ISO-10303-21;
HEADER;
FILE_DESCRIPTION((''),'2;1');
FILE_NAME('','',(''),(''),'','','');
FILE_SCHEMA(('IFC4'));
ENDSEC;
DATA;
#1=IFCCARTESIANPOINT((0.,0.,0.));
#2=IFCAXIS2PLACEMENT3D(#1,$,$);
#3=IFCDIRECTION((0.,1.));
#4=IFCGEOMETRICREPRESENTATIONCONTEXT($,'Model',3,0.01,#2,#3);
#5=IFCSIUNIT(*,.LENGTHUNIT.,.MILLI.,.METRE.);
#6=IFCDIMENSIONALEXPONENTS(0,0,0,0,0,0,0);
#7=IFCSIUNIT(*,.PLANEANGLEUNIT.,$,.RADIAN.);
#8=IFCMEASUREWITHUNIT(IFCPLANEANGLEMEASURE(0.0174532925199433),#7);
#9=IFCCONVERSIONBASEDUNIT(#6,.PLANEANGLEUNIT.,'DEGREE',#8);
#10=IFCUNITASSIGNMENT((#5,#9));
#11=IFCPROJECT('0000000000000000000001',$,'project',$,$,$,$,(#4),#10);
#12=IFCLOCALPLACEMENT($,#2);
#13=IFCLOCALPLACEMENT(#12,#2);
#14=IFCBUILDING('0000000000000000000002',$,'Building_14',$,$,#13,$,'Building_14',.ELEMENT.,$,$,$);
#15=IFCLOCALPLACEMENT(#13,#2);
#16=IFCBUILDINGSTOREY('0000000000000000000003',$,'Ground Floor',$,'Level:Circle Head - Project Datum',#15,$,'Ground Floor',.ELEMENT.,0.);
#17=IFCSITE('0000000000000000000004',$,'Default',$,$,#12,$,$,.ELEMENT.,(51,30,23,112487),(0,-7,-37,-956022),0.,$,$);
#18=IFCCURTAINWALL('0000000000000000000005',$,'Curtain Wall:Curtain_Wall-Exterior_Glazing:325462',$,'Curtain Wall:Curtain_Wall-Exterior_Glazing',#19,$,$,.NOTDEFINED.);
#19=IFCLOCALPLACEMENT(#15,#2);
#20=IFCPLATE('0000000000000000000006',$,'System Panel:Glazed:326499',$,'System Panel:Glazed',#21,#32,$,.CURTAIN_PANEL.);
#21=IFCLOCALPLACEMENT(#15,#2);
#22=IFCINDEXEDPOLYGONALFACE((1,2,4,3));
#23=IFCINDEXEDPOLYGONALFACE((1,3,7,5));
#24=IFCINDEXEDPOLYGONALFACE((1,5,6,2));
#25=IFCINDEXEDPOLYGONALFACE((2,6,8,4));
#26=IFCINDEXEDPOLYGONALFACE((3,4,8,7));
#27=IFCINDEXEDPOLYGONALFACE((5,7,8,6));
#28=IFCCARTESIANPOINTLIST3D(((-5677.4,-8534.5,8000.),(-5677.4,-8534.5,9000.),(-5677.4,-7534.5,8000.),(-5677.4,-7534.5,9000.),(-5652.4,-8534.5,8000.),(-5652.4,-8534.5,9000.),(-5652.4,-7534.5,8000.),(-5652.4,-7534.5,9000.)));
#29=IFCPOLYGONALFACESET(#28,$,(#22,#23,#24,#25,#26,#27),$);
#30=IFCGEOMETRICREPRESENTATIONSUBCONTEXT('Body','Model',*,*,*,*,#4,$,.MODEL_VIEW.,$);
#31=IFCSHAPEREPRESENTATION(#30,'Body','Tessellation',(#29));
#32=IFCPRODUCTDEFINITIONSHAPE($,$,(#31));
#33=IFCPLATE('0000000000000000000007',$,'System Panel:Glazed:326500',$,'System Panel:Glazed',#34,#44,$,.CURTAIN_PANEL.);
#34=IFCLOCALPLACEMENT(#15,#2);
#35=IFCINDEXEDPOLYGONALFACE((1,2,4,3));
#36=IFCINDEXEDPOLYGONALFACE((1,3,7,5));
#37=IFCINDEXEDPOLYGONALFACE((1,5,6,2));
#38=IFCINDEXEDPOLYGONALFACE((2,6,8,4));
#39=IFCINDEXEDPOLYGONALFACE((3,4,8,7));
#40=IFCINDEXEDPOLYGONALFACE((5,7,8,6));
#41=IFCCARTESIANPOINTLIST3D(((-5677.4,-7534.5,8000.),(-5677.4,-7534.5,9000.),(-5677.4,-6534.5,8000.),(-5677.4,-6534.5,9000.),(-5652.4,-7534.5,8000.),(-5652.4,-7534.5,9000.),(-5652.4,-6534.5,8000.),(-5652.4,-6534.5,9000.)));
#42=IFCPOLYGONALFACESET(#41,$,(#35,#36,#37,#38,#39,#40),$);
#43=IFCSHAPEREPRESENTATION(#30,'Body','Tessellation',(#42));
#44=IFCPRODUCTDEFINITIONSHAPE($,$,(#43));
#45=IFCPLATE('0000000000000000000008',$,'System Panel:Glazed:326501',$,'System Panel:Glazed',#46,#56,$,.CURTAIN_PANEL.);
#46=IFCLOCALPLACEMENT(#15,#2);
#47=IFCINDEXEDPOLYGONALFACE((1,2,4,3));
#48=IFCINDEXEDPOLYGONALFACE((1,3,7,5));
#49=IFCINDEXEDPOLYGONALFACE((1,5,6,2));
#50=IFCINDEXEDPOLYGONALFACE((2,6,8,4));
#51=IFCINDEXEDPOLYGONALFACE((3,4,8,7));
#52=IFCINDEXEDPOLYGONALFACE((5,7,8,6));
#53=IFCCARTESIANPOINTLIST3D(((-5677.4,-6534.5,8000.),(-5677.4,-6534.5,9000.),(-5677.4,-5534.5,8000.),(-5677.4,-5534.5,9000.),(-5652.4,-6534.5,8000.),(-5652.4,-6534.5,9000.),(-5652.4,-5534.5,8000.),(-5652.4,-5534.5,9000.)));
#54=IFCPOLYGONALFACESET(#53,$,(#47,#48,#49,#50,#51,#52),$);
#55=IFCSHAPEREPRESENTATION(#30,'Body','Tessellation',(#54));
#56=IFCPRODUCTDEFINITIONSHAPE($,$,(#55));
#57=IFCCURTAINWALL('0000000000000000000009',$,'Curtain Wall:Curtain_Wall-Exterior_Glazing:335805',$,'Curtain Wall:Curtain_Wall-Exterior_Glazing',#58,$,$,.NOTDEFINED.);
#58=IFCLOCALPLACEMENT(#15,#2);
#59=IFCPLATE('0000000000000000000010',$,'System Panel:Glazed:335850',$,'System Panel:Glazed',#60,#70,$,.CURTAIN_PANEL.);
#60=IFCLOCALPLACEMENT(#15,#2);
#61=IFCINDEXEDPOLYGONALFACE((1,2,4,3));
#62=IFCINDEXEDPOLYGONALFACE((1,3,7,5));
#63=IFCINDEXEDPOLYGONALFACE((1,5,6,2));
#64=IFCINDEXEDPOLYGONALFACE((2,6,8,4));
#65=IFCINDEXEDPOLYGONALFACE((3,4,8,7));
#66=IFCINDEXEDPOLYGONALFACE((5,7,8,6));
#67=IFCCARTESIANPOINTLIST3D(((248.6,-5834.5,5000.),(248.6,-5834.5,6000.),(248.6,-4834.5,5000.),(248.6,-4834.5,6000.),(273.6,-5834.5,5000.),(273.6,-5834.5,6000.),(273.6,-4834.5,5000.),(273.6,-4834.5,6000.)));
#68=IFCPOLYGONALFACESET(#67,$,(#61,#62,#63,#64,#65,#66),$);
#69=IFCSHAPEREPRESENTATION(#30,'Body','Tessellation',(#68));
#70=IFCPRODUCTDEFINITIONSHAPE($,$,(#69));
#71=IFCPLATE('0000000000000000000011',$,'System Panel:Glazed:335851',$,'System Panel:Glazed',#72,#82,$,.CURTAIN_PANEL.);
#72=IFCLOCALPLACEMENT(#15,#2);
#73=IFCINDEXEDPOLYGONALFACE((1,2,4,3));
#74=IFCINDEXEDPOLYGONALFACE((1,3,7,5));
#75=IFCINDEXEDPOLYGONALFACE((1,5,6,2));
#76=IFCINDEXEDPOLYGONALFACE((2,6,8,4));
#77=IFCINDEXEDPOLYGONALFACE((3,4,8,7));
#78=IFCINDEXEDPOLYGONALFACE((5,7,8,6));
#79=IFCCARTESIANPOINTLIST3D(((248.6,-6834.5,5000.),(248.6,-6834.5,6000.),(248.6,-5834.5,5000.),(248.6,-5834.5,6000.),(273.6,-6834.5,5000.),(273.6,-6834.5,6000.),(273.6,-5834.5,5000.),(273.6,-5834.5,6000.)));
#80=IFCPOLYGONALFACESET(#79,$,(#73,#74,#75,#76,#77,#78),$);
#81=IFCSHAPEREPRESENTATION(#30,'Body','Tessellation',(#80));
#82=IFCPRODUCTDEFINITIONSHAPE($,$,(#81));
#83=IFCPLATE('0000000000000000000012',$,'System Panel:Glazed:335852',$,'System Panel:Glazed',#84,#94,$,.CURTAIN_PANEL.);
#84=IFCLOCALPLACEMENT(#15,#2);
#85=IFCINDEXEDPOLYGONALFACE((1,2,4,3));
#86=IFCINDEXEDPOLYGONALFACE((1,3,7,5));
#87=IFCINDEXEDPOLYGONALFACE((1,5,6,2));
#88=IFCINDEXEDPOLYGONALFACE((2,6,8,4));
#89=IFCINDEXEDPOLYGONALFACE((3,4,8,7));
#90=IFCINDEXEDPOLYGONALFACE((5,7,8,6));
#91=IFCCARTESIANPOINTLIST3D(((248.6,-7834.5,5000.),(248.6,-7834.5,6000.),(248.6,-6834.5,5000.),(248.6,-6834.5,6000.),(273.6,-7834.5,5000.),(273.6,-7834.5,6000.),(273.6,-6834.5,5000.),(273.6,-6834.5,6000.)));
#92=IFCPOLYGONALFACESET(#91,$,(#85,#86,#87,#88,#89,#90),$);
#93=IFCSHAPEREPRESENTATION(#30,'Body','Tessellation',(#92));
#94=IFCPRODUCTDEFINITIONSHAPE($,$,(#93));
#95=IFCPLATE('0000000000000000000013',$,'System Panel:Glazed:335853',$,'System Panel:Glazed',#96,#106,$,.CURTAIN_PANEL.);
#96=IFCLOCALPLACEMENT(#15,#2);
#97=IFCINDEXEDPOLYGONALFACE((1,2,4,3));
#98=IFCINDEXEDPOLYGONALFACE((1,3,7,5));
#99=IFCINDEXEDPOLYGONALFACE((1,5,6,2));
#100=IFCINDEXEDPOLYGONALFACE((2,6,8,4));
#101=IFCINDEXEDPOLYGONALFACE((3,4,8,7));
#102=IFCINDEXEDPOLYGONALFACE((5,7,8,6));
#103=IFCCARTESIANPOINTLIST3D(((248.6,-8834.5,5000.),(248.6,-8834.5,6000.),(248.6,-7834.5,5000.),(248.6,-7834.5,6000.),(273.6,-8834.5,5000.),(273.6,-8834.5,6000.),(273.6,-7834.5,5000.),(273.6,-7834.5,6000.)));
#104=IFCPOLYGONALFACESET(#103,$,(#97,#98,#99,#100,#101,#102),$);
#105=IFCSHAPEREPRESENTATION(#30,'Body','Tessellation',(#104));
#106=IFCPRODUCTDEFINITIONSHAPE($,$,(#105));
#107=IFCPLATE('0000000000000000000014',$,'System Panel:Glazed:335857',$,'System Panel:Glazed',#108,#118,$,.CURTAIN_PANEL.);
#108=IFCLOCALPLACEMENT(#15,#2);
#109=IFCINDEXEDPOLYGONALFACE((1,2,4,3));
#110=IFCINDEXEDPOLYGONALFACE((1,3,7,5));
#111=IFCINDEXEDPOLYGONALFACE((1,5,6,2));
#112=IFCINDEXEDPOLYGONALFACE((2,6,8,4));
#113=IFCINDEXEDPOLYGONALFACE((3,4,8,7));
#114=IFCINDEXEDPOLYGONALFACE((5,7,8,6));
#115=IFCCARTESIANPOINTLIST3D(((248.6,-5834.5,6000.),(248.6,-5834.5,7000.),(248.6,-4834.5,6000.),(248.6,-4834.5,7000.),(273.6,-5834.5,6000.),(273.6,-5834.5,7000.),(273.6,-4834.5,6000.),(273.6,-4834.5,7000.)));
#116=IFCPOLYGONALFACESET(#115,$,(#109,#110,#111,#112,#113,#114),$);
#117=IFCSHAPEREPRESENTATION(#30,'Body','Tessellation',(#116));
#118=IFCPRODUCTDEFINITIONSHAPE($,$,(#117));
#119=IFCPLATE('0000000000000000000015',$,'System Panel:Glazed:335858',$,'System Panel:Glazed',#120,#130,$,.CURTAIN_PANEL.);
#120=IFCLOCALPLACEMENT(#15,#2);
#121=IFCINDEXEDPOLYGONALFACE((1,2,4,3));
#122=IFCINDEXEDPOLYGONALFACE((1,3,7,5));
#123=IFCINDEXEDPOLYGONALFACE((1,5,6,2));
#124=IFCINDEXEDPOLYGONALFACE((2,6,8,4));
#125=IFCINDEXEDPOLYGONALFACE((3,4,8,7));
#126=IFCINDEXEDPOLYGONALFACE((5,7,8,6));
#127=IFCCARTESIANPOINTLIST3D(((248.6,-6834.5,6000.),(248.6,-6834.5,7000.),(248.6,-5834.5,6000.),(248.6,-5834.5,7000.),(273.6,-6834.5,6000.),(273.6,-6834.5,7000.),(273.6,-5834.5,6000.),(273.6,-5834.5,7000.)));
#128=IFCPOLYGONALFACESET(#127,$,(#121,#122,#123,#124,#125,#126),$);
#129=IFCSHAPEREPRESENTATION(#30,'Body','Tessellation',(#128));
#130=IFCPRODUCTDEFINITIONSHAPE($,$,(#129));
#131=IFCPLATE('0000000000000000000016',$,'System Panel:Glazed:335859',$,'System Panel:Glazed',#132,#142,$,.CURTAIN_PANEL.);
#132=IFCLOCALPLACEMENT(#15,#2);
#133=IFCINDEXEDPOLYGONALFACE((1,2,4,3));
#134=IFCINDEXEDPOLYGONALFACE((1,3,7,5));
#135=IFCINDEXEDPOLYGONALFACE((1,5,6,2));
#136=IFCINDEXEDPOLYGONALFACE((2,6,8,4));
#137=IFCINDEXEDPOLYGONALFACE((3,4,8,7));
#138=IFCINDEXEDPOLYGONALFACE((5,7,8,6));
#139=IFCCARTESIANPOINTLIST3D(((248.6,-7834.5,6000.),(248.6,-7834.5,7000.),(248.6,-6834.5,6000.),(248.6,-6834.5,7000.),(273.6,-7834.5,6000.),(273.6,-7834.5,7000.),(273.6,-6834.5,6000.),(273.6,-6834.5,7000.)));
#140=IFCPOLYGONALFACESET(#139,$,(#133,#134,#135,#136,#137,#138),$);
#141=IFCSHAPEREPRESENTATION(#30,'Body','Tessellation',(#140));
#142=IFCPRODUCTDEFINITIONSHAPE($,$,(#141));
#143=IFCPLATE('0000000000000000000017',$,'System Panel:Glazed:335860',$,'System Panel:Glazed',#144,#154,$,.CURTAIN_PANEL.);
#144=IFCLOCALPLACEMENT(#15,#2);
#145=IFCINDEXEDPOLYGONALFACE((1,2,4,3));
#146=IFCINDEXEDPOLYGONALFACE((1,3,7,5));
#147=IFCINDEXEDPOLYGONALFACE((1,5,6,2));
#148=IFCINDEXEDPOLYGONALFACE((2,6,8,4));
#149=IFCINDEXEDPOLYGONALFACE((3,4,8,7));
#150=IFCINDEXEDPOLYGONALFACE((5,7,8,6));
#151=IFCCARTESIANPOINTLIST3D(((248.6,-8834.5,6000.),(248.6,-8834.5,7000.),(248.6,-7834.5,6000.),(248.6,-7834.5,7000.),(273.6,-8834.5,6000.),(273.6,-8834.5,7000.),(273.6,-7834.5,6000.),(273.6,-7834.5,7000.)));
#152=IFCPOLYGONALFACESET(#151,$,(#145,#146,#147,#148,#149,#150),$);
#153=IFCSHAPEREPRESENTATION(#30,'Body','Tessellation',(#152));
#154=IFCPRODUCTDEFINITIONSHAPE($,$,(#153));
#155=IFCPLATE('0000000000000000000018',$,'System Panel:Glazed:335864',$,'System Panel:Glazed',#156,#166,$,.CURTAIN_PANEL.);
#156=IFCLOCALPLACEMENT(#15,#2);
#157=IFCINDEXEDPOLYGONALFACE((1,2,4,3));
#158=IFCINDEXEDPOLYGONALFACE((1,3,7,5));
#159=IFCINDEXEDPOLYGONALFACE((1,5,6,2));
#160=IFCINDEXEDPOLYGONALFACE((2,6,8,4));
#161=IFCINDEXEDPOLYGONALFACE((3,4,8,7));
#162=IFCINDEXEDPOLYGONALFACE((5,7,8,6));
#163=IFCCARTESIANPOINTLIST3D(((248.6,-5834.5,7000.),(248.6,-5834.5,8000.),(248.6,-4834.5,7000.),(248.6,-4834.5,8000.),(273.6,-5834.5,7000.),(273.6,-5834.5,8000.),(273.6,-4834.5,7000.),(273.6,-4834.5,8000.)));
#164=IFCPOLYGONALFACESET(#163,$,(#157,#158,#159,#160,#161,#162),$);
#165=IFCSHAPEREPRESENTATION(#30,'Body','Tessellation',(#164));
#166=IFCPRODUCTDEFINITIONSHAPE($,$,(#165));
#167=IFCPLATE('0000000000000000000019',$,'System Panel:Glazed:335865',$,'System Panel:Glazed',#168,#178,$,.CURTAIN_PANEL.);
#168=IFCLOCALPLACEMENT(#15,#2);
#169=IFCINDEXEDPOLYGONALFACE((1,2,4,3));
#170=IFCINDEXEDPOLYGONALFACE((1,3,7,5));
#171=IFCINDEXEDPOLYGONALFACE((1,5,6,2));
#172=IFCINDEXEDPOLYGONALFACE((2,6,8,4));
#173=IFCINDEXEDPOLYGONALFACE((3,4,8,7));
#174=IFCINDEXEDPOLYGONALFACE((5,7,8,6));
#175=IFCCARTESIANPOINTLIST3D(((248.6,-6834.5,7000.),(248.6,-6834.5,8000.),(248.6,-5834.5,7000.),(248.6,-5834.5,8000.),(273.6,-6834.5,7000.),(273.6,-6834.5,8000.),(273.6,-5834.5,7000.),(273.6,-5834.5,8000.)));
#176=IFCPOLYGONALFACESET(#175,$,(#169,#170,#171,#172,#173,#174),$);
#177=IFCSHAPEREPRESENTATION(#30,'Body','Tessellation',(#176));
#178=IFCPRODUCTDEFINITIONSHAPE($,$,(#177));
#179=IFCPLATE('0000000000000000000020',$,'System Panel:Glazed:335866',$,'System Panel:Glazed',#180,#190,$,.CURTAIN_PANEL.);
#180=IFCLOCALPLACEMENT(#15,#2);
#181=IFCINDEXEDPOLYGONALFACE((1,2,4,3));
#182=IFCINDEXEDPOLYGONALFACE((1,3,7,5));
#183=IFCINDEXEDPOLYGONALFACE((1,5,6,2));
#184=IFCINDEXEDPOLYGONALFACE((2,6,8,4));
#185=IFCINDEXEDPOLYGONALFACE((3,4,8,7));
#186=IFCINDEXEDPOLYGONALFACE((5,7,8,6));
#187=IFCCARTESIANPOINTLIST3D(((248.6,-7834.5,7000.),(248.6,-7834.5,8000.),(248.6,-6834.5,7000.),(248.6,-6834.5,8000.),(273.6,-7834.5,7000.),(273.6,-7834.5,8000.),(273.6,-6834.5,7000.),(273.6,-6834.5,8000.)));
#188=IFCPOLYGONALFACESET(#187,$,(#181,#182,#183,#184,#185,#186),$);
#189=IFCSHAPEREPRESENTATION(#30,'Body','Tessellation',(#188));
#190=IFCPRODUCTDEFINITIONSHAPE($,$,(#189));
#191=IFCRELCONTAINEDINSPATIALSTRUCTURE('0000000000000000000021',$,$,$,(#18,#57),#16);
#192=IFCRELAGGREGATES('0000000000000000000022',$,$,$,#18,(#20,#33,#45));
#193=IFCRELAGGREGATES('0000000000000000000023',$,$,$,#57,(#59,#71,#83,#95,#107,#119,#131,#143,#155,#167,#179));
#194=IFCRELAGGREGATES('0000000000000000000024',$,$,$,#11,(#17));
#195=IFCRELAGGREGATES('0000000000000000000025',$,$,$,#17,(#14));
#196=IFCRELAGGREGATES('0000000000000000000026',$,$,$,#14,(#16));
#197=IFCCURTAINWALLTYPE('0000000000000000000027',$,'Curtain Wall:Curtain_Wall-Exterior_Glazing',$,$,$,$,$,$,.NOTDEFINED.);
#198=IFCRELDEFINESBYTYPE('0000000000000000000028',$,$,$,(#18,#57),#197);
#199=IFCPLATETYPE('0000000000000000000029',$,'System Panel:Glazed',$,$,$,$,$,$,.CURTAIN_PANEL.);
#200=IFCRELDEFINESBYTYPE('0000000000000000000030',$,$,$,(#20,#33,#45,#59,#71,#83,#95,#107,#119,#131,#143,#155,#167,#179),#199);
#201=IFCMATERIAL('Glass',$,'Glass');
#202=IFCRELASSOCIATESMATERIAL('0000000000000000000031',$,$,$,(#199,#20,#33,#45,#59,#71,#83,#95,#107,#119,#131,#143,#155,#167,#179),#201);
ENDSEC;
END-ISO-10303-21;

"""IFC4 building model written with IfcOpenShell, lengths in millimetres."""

from ifc_helpers import new_model, entity, si_unit, converted_unit, direction, frame, origin, place, context, subcontext, project, spatial, indexed_curve, outline, extrude, source, transform, mapped, material, type_object, type_shapes, element, aggregate, save


model = new_model("IFC4")

# Units and contexts
model_context = context("Model", 3, precision=0.01, world=origin(), true_north=direction((0.0, 1.0)))
body_context = subcontext(model_context, "Body", "Model", "MODEL_VIEW")
ifc_project = project(units=[si_unit("LENGTHUNIT", "METRE", prefix="MILLI"), converted_unit("PLANEANGLEUNIT", "DEGREE", entity("IfcPlaneAngleMeasure", 0.0174532925199433), si_unit("PLANEANGLEUNIT", "RADIAN"), dimensions=[0, 0, 0, 0, 0, 0, 0])], contexts=[model_context])

# Site, building, storey
site_placement = place(None, origin())
site = spatial("IfcSite", under=ifc_project, at=site_placement, Name="Default", CompositionType="ELEMENT", RefLatitude=(51, 30, 23, 112487), RefLongitude=(0, -7, -37, -956022), RefElevation=0.0)
building_placement = place(site_placement, origin())
building = spatial("IfcBuilding", under=site, at=building_placement, Name="Building_14", LongName="Building_14", CompositionType="ELEMENT")
storey_placement = place(building_placement, origin())
storey = spatial("IfcBuildingStorey", under=building, at=storey_placement, Name="Ground Floor", ObjectType="Level:Circle Head - Project Datum", LongName="Ground Floor", CompositionType="ELEMENT", Elevation=0.0)

# Curtain walls, plates
curtain_wall_type = type_object("IfcCurtainWallType", Name="Curtain Wall:Curtain_Wall-Exterior_Glazing", PredefinedType="NOTDEFINED")
curtain_wall_1_placement = place(storey_placement, origin())
curtain_wall_1 = element("IfcCurtainWall", 1, at=curtain_wall_1_placement, inside=storey, type_object=curtain_wall_type, Name="Curtain Wall:Curtain_Wall-Exterior_Glazing:325462", ObjectType="Curtain Wall:Curtain_Wall-Exterior_Glazing", PredefinedType="NOTDEFINED")
ifc_material = material(Name="Glass", Category="Glass")
plate_type = type_object("IfcPlateType", Name="System Panel:Glazed", PredefinedType="CURTAIN_PANEL", material=ifc_material)
shared_shape = source(origin(), body_context, "Body", "SweptSolid", [
    extrude(outline(indexed_curve([(-12.5, -500.0), (12.5, -500.0), (12.5, 500.0), (-12.5, 500.0), (-12.5, -500.0)], self_intersect=False)), frame((0.0, -37.0, 0.0), z_axis=(0.0, 0.0, 1.0), x_axis=(0.0, 1.0, 0.0)), (0.0, 0.0, 1.0), 1000.0),
])
type_shapes(plate_type, [shared_shape])
plate_1_placement = place(curtain_wall_1_placement, frame((-5701.9, -8034.5, 8000.0), z_axis=(0.0, 0.0, 1.0), x_axis=(0.0, 1.0, 0.0)))
plate_1 = element("IfcPlate", 2, at=plate_1_placement, type_object=plate_type, material=ifc_material, Name="System Panel:Glazed:326499", ObjectType="System Panel:Glazed", PredefinedType="CURTAIN_PANEL", context=body_context, shape_type="MappedRepresentation", body=[
    mapped(shared_shape, transform((0.0, 0.0, 0.0), scale=1.0)),
])
plate_2_placement = place(curtain_wall_1_placement, frame((-5701.9, -7034.5, 8000.0), z_axis=(0.0, 0.0, 1.0), x_axis=(0.0, 1.0, 0.0)))
plate_2 = element("IfcPlate", 3, at=plate_2_placement, type_object=plate_type, material=ifc_material, Name="System Panel:Glazed:326500", ObjectType="System Panel:Glazed", PredefinedType="CURTAIN_PANEL", context=body_context, shape_type="MappedRepresentation", body=[
    mapped(shared_shape, transform((0.0, 0.0, 0.0), scale=1.0)),
])
plate_3_placement = place(curtain_wall_1_placement, frame((-5701.9, -6034.5, 8000.0), z_axis=(0.0, 0.0, 1.0), x_axis=(0.0, 1.0, 0.0)))
plate_3 = element("IfcPlate", 4, at=plate_3_placement, type_object=plate_type, material=ifc_material, Name="System Panel:Glazed:326501", ObjectType="System Panel:Glazed", PredefinedType="CURTAIN_PANEL", context=body_context, shape_type="MappedRepresentation", body=[
    mapped(shared_shape, transform((0.0, 0.0, 0.0), scale=1.0)),
])
aggregate(curtain_wall_1, [plate_1, plate_2, plate_3])
curtain_wall_2_placement = place(storey_placement, origin())
curtain_wall_2 = element("IfcCurtainWall", 5, at=curtain_wall_2_placement, inside=storey, type_object=curtain_wall_type, Name="Curtain Wall:Curtain_Wall-Exterior_Glazing:335805", ObjectType="Curtain Wall:Curtain_Wall-Exterior_Glazing", PredefinedType="NOTDEFINED")
plate_4_placement = place(curtain_wall_2_placement, frame((298.1, -5334.5, 5000.0), z_axis=(0.0, 0.0, 1.0), x_axis=(0.0, -1.0, 0.0)))
plate_4 = element("IfcPlate", 6, at=plate_4_placement, type_object=plate_type, material=ifc_material, Name="System Panel:Glazed:335850", ObjectType="System Panel:Glazed", PredefinedType="CURTAIN_PANEL", context=body_context, shape_type="MappedRepresentation", body=[
    mapped(shared_shape, transform((0.0, 0.0, 0.0), scale=1.0)),
])
plate_5_placement = place(curtain_wall_2_placement, frame((298.1, -6334.5, 5000.0), z_axis=(0.0, 0.0, 1.0), x_axis=(0.0, -1.0, 0.0)))
plate_5 = element("IfcPlate", 7, at=plate_5_placement, type_object=plate_type, material=ifc_material, Name="System Panel:Glazed:335851", ObjectType="System Panel:Glazed", PredefinedType="CURTAIN_PANEL", context=body_context, shape_type="MappedRepresentation", body=[
    mapped(shared_shape, transform((0.0, 0.0, 0.0), scale=1.0)),
])
plate_6_placement = place(curtain_wall_2_placement, frame((298.1, -7334.5, 5000.0), z_axis=(0.0, 0.0, 1.0), x_axis=(0.0, -1.0, 0.0)))
plate_6 = element("IfcPlate", 8, at=plate_6_placement, type_object=plate_type, material=ifc_material, Name="System Panel:Glazed:335852", ObjectType="System Panel:Glazed", PredefinedType="CURTAIN_PANEL", context=body_context, shape_type="MappedRepresentation", body=[
    mapped(shared_shape, transform((0.0, 0.0, 0.0), scale=1.0)),
])
plate_7_placement = place(curtain_wall_2_placement, frame((298.1, -8334.5, 5000.0), z_axis=(0.0, 0.0, 1.0), x_axis=(0.0, -1.0, 0.0)))
plate_7 = element("IfcPlate", 9, at=plate_7_placement, type_object=plate_type, material=ifc_material, Name="System Panel:Glazed:335853", ObjectType="System Panel:Glazed", PredefinedType="CURTAIN_PANEL", context=body_context, shape_type="MappedRepresentation", body=[
    mapped(shared_shape, transform((0.0, 0.0, 0.0), scale=1.0)),
])
plate_8_placement = place(curtain_wall_2_placement, frame((298.1, -5334.5, 6000.0), z_axis=(0.0, 0.0, 1.0), x_axis=(0.0, -1.0, 0.0)))
plate_8 = element("IfcPlate", 10, at=plate_8_placement, type_object=plate_type, material=ifc_material, Name="System Panel:Glazed:335857", ObjectType="System Panel:Glazed", PredefinedType="CURTAIN_PANEL", context=body_context, shape_type="MappedRepresentation", body=[
    mapped(shared_shape, transform((0.0, 0.0, 0.0), scale=1.0)),
])
plate_9_placement = place(curtain_wall_2_placement, frame((298.1, -6334.5, 6000.0), z_axis=(0.0, 0.0, 1.0), x_axis=(0.0, -1.0, 0.0)))
plate_9 = element("IfcPlate", 11, at=plate_9_placement, type_object=plate_type, material=ifc_material, Name="System Panel:Glazed:335858", ObjectType="System Panel:Glazed", PredefinedType="CURTAIN_PANEL", context=body_context, shape_type="MappedRepresentation", body=[
    mapped(shared_shape, transform((0.0, 0.0, 0.0), scale=1.0)),
])
plate_10_placement = place(curtain_wall_2_placement, frame((298.1, -7334.5, 6000.0), z_axis=(0.0, 0.0, 1.0), x_axis=(0.0, -1.0, 0.0)))
plate_10 = element("IfcPlate", 12, at=plate_10_placement, type_object=plate_type, material=ifc_material, Name="System Panel:Glazed:335859", ObjectType="System Panel:Glazed", PredefinedType="CURTAIN_PANEL", context=body_context, shape_type="MappedRepresentation", body=[
    mapped(shared_shape, transform((0.0, 0.0, 0.0), scale=1.0)),
])
plate_11_placement = place(curtain_wall_2_placement, frame((298.1, -8334.5, 6000.0), z_axis=(0.0, 0.0, 1.0), x_axis=(0.0, -1.0, 0.0)))
plate_11 = element("IfcPlate", 13, at=plate_11_placement, type_object=plate_type, material=ifc_material, Name="System Panel:Glazed:335860", ObjectType="System Panel:Glazed", PredefinedType="CURTAIN_PANEL", context=body_context, shape_type="MappedRepresentation", body=[
    mapped(shared_shape, transform((0.0, 0.0, 0.0), scale=1.0)),
])
plate_12_placement = place(curtain_wall_2_placement, frame((298.1, -5334.5, 7000.0), z_axis=(0.0, 0.0, 1.0), x_axis=(0.0, -1.0, 0.0)))
plate_12 = element("IfcPlate", 14, at=plate_12_placement, type_object=plate_type, material=ifc_material, Name="System Panel:Glazed:335864", ObjectType="System Panel:Glazed", PredefinedType="CURTAIN_PANEL", context=body_context, shape_type="MappedRepresentation", body=[
    mapped(shared_shape, transform((0.0, 0.0, 0.0), scale=1.0)),
])
plate_13_placement = place(curtain_wall_2_placement, frame((298.1, -6334.5, 7000.0), z_axis=(0.0, 0.0, 1.0), x_axis=(0.0, -1.0, 0.0)))
plate_13 = element("IfcPlate", 15, at=plate_13_placement, type_object=plate_type, material=ifc_material, Name="System Panel:Glazed:335865", ObjectType="System Panel:Glazed", PredefinedType="CURTAIN_PANEL", context=body_context, shape_type="MappedRepresentation", body=[
    mapped(shared_shape, transform((0.0, 0.0, 0.0), scale=1.0)),
])
plate_14_placement = place(curtain_wall_2_placement, frame((298.1, -7334.5, 7000.0), z_axis=(0.0, 0.0, 1.0), x_axis=(0.0, -1.0, 0.0)))
plate_14 = element("IfcPlate", 16, at=plate_14_placement, type_object=plate_type, material=ifc_material, Name="System Panel:Glazed:335866", ObjectType="System Panel:Glazed", PredefinedType="CURTAIN_PANEL", context=body_context, shape_type="MappedRepresentation", body=[
    mapped(shared_shape, transform((0.0, 0.0, 0.0), scale=1.0)),
])
aggregate(curtain_wall_2, [plate_4, plate_5, plate_6, plate_7, plate_8, plate_9, plate_10, plate_11, plate_12, plate_13, plate_14])

save(model, "model.ifc")
